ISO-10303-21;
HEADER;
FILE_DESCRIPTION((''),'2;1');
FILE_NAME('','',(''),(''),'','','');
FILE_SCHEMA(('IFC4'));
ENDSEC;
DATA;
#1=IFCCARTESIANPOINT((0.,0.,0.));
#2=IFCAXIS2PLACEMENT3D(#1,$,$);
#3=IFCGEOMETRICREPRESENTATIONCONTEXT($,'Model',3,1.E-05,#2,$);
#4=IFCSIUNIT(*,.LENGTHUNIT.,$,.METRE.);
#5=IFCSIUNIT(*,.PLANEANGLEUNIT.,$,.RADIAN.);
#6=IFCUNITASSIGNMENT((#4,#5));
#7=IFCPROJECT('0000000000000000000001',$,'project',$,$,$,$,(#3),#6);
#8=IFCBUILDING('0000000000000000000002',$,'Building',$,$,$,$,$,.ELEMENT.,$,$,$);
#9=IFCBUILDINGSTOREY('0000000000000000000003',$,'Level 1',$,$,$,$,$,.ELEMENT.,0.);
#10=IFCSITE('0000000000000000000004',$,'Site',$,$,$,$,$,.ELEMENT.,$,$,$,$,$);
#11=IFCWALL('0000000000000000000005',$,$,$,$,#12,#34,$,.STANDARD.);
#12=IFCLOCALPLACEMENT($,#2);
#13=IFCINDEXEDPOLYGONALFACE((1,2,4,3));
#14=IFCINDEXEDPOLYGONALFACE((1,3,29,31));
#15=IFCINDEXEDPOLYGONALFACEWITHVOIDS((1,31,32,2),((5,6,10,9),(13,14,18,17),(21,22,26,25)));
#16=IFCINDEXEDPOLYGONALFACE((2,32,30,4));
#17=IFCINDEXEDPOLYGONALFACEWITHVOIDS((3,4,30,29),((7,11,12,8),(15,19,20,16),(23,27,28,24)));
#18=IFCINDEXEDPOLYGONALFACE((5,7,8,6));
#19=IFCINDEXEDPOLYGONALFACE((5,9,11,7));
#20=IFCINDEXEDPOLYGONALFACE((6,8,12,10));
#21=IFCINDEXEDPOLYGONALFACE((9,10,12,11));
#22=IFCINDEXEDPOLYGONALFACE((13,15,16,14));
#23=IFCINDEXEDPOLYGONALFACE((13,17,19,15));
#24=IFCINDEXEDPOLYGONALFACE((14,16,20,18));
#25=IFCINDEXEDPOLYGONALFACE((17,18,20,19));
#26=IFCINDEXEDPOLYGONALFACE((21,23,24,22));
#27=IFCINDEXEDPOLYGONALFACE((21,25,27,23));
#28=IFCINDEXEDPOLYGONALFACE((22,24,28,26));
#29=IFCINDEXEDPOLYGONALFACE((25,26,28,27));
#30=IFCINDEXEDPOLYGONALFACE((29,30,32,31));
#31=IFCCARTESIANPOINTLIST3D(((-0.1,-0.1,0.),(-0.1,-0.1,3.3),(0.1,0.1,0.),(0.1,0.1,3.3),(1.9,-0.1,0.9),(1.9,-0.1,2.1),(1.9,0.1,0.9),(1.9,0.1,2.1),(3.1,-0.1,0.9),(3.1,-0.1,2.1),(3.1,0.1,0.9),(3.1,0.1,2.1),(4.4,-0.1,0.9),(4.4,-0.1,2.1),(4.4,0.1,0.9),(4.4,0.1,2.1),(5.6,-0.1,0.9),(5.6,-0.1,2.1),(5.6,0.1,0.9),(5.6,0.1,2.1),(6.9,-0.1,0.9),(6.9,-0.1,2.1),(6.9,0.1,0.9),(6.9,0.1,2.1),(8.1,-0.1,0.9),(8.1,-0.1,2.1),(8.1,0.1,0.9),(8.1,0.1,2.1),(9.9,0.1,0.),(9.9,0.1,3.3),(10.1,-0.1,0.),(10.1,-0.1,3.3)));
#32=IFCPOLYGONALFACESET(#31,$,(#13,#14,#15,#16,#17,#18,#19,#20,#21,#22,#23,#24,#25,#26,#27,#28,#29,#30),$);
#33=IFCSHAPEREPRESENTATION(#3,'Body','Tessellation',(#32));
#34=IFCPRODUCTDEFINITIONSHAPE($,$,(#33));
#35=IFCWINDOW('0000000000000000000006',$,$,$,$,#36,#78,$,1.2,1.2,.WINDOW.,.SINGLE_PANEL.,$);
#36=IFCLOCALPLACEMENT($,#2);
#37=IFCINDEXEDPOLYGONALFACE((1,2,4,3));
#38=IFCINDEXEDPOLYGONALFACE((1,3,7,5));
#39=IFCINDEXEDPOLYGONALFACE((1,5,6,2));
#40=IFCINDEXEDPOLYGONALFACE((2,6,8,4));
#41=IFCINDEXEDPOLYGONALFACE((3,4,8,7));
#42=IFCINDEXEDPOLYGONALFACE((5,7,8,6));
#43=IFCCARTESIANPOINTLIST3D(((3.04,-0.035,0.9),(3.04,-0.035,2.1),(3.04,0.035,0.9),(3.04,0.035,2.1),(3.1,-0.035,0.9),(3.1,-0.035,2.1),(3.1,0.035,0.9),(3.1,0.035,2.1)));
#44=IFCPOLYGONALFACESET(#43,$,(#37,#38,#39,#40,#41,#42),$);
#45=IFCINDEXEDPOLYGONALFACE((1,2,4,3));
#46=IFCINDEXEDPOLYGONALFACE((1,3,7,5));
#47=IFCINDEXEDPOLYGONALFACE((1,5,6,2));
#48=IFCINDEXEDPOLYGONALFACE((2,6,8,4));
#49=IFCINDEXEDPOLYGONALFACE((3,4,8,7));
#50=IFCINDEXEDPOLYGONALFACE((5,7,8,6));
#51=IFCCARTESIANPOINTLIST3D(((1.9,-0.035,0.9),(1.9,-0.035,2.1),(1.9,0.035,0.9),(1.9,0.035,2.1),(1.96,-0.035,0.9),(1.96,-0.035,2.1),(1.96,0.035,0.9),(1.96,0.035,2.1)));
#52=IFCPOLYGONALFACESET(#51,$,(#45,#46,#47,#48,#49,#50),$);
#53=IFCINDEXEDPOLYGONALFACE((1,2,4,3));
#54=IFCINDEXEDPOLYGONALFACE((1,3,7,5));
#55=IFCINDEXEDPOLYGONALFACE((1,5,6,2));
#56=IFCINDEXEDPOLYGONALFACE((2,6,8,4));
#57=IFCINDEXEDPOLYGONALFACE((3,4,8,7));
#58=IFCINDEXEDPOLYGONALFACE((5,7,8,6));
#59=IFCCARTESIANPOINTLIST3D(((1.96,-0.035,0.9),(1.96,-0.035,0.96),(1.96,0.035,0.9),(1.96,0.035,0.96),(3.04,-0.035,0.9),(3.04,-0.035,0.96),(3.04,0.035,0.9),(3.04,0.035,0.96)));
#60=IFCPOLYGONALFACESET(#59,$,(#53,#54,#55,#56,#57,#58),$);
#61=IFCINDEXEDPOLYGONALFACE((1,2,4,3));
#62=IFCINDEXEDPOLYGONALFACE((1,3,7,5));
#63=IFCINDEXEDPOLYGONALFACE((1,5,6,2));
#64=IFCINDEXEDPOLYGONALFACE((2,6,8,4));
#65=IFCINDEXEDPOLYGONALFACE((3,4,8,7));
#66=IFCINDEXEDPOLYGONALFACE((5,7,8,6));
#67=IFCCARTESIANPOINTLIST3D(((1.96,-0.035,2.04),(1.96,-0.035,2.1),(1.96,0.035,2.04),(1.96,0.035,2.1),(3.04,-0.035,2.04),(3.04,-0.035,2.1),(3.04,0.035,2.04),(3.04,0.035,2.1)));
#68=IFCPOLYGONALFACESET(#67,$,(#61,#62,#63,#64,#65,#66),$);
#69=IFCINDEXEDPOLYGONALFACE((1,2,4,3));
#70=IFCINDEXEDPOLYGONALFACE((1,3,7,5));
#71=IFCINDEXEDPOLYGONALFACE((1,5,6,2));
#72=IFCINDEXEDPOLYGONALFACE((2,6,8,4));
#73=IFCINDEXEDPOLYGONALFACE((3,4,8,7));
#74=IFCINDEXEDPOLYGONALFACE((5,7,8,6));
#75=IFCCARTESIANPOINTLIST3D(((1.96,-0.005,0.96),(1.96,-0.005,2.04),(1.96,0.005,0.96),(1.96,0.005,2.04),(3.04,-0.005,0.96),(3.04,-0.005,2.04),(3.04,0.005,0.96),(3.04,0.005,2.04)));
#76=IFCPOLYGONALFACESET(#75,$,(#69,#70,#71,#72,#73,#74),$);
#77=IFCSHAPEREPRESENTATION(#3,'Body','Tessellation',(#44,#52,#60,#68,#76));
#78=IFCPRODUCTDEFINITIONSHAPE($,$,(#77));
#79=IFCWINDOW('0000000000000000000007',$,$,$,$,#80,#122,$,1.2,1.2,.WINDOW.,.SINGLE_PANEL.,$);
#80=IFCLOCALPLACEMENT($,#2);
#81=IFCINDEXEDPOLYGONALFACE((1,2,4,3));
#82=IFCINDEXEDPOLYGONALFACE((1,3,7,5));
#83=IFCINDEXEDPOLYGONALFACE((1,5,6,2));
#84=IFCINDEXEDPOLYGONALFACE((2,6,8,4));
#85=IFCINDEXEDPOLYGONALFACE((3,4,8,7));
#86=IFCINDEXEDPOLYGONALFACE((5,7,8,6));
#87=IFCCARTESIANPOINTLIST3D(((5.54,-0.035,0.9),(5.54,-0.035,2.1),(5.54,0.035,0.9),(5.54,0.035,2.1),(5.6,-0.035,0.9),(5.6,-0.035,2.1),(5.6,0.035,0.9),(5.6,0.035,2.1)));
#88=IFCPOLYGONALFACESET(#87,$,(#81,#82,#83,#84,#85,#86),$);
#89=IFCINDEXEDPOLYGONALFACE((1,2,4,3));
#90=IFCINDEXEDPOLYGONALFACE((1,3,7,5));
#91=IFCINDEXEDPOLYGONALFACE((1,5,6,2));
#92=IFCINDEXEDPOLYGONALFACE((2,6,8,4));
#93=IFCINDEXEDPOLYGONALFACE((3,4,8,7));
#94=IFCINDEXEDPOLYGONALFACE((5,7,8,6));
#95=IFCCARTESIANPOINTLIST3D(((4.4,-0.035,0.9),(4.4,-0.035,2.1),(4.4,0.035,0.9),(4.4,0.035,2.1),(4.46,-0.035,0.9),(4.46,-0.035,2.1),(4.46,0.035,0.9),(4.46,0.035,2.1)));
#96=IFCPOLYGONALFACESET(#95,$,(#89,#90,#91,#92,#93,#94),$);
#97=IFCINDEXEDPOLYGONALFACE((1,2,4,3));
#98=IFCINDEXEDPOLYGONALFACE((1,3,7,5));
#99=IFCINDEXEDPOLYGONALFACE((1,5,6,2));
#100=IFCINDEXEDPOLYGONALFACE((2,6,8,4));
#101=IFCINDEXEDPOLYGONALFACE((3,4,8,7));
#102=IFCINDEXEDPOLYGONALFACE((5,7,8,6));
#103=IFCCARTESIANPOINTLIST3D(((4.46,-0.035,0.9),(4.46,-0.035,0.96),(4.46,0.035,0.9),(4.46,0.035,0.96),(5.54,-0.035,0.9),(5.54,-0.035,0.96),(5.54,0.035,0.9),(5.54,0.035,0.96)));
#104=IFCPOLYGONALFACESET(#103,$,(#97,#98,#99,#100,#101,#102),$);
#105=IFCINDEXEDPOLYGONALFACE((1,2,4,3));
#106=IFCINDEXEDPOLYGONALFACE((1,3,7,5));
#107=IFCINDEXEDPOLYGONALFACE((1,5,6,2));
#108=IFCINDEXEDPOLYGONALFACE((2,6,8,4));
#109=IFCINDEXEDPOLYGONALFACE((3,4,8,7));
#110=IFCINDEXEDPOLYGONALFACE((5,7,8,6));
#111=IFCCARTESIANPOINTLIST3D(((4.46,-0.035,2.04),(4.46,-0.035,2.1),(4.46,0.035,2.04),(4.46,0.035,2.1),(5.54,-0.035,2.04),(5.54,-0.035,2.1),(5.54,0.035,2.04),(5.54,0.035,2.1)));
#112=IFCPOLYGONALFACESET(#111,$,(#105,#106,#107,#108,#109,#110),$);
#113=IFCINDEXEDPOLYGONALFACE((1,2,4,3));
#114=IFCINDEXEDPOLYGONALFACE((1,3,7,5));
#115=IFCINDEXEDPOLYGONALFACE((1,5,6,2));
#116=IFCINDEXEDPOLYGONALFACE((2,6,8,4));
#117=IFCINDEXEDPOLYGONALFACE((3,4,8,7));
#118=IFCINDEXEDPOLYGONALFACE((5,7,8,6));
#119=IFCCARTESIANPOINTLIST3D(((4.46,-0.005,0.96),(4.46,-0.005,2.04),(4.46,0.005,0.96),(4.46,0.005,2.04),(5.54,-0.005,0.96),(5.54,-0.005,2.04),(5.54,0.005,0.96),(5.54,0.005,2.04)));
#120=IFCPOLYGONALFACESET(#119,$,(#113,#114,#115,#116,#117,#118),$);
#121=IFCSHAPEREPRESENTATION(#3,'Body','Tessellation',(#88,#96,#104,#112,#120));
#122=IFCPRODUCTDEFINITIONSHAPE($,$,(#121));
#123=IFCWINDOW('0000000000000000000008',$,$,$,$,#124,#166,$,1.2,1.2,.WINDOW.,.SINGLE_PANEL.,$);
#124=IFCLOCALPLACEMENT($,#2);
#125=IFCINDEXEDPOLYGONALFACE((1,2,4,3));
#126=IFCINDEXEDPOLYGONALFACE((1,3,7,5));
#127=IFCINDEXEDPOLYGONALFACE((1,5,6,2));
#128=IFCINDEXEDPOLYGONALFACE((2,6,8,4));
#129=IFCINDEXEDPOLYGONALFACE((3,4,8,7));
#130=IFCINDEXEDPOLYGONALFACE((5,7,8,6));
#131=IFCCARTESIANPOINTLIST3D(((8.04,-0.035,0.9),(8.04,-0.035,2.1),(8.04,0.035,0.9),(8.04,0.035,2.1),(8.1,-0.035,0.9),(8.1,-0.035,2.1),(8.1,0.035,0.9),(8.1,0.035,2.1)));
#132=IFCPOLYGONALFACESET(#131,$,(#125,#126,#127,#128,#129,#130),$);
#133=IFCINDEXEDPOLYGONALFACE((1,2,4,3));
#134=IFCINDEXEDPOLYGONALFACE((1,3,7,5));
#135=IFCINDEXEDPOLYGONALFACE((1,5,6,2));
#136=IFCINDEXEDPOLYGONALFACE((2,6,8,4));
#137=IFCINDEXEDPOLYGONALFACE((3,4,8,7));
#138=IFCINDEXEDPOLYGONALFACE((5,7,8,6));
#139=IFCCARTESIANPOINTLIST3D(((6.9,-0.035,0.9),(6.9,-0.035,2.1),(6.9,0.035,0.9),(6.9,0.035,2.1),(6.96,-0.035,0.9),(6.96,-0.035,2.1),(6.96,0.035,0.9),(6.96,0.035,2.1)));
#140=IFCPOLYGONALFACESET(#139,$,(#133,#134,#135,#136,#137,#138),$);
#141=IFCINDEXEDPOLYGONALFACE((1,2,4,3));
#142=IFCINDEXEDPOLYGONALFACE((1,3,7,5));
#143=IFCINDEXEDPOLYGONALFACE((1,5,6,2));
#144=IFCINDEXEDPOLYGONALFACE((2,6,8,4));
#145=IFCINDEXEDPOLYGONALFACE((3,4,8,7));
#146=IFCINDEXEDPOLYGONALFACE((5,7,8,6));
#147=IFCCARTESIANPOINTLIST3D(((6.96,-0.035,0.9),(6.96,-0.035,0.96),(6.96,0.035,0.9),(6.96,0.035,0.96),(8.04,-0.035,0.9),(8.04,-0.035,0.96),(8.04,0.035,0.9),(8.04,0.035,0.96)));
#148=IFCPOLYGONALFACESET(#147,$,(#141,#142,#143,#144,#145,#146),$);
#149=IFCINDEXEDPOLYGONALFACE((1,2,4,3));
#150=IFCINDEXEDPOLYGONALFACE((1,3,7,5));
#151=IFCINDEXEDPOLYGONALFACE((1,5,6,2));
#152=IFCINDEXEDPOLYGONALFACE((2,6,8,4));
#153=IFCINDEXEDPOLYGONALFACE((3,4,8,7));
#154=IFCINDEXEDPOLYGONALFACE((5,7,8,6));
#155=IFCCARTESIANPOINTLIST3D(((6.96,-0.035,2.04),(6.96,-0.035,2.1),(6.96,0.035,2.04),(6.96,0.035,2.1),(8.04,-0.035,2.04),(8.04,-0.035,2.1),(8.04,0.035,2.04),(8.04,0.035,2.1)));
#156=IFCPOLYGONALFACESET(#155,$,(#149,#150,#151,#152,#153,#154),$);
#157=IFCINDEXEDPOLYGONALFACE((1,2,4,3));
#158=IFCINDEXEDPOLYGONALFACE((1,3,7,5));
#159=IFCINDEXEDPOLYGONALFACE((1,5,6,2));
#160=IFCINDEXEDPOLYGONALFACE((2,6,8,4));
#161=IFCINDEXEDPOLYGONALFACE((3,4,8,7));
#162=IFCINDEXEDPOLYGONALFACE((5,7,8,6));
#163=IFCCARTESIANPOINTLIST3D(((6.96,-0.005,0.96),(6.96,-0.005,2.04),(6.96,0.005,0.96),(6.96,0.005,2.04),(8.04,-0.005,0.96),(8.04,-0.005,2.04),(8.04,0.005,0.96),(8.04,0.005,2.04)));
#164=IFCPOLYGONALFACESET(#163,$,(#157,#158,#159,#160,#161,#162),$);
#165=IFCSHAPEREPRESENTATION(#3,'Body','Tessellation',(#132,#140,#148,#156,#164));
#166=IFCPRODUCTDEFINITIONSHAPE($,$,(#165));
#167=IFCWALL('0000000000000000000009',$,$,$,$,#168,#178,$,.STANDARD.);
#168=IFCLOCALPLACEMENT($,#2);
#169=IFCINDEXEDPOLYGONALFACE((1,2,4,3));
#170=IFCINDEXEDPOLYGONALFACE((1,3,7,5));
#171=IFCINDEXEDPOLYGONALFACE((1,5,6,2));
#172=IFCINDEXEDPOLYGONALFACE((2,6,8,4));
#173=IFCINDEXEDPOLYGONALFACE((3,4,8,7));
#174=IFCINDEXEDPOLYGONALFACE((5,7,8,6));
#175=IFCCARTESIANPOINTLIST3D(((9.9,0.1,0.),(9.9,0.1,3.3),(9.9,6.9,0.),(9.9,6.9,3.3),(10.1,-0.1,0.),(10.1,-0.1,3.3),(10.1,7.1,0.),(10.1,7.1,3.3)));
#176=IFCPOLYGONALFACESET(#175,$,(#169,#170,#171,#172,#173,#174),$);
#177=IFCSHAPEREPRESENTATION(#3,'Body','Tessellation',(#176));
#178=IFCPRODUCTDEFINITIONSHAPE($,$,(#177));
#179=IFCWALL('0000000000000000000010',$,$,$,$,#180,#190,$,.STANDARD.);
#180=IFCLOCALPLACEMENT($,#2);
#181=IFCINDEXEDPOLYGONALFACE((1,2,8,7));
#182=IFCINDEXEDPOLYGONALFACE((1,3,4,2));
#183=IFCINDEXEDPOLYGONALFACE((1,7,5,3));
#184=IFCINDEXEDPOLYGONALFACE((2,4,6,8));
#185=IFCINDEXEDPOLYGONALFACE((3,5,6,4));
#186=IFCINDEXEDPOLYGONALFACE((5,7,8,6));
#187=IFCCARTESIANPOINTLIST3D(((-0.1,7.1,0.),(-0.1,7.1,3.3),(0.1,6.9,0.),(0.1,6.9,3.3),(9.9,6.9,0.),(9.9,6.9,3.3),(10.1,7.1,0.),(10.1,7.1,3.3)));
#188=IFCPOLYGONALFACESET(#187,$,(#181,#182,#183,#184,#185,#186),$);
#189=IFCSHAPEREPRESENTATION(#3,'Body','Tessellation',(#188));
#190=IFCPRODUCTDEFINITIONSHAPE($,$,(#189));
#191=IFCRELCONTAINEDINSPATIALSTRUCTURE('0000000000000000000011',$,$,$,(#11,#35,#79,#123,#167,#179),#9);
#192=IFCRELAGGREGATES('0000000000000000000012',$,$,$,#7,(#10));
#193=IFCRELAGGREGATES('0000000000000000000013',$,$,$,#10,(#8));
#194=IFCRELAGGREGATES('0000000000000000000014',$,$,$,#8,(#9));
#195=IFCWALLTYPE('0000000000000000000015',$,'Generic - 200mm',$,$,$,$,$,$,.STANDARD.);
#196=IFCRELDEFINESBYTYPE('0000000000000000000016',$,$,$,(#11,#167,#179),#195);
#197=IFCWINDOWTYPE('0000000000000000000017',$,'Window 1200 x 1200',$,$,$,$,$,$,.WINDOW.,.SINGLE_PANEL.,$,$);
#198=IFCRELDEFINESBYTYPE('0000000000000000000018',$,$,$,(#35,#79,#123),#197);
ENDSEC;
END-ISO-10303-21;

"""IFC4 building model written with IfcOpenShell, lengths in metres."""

from ifc_helpers import new_model, si_unit, frame, frame_2d, origin, origin_with_axes, origin_2d, place, context, project, spatial, polyline, rectangle, outline, extrude, type_object, element, fill, save


model = new_model("IFC4")

# Units and contexts
model_context = context("Model", 3, precision=1e-05, world=origin())
ifc_project = project(units=[si_unit("LENGTHUNIT", "METRE"), si_unit("PLANEANGLEUNIT", "RADIAN")], contexts=[model_context])

# Site, building, storey
site = spatial("IfcSite", under=ifc_project, Name="Site", CompositionType="ELEMENT")
building = spatial("IfcBuilding", under=site, Name="Building", CompositionType="ELEMENT")
storey = spatial("IfcBuildingStorey", under=building, Name="Level 1", CompositionType="ELEMENT", Elevation=0.0)

# Wall, openings, windows
wall_type = type_object("IfcWallType", Name="Generic - 200mm", PredefinedType="STANDARD")
wall_1_placement = place(None, frame((10.0, 0.0, 0.0), z_axis=(0.0, 0.0, 1.0), x_axis=(-1.0, 0.0, 0.0)))
wall_1 = element("IfcWall", 1, at=wall_1_placement, inside=storey, type_object=wall_type, PredefinedType="STANDARD", context=model_context, shape_type="SweptSolid", body=[
    extrude(outline(polyline([(0.1, -0.1), (9.9, -0.1), (10.1, 0.1), (-0.1, 0.1), (0.1, -0.1)])), origin(), (0.0, 0.0, 1.0), 3.3),
])
opening_1_placement = place(wall_1_placement, frame((7.5, 0.0, 0.9), z_axis=(0.0, 0.0, 1.0), x_axis=(1.0, 0.0, 0.0)))
opening_1 = element("IfcOpeningElement", 2, at=opening_1_placement, cuts=wall_1, PredefinedType="OPENING", context=model_context, shape_type="SweptSolid", body=[
    extrude(rectangle(XDim=1.2, YDim=0.202, at=origin_2d()), origin(), (0.0, 0.0, 1.0), 1.2),
])
opening_2_placement = place(wall_1_placement, frame((5.0, 0.0, 0.9), z_axis=(0.0, 0.0, 1.0), x_axis=(1.0, 0.0, 0.0)))
opening_2 = element("IfcOpeningElement", 3, at=opening_2_placement, cuts=wall_1, PredefinedType="OPENING", context=model_context, shape_type="SweptSolid", body=[
    extrude(rectangle(XDim=1.2, YDim=0.202, at=origin_2d()), origin(), (0.0, 0.0, 1.0), 1.2),
])
opening_3_placement = place(wall_1_placement, frame((2.5, 0.0, 0.9), z_axis=(0.0, 0.0, 1.0), x_axis=(1.0, 0.0, 0.0)))
opening_3 = element("IfcOpeningElement", 4, at=opening_3_placement, cuts=wall_1, PredefinedType="OPENING", context=model_context, shape_type="SweptSolid", body=[
    extrude(rectangle(XDim=1.2, YDim=0.202, at=origin_2d()), origin(), (0.0, 0.0, 1.0), 1.2),
])
window_type = type_object("IfcWindowType", Name="Window 1200 x 1200", PartitioningType="SINGLE_PANEL", PredefinedType="WINDOW")
window_1_placement = place(opening_1_placement, origin_with_axes())
window_1 = element("IfcWindow", 5, at=window_1_placement, inside=storey, type_object=window_type, OverallHeight=1.2, OverallWidth=1.2, PartitioningType="SINGLE_PANEL", PredefinedType="WINDOW", context=model_context, shape_type="SweptSolid", body=[
    extrude(rectangle(XDim=0.06, YDim=0.07, at=frame_2d((-0.57, 0.0))), origin(), (0.0, 0.0, 1.0), 1.2),
    extrude(rectangle(XDim=0.06, YDim=0.07, at=frame_2d((0.57, 0.0))), origin(), (0.0, 0.0, 1.0), 1.2),
    extrude(rectangle(XDim=1.08, YDim=0.07, at=origin_2d()), origin(), (0.0, 0.0, 1.0), 0.06),
    extrude(rectangle(XDim=1.08, YDim=0.07, at=origin_2d()), frame((0.0, 0.0, 1.14)), (0.0, 0.0, 1.0), 0.06),
    extrude(rectangle(XDim=1.08, YDim=0.01, at=origin_2d()), frame((0.0, 0.0, 0.06)), (0.0, 0.0, 1.0), 1.08),
])
fill(opening_1, window_1)
window_2_placement = place(opening_2_placement, origin_with_axes())
window_2 = element("IfcWindow", 6, at=window_2_placement, inside=storey, type_object=window_type, OverallHeight=1.2, OverallWidth=1.2, PartitioningType="SINGLE_PANEL", PredefinedType="WINDOW", context=model_context, shape_type="SweptSolid", body=[
    extrude(rectangle(XDim=0.06, YDim=0.07, at=frame_2d((-0.57, 0.0))), origin(), (0.0, 0.0, 1.0), 1.2),
    extrude(rectangle(XDim=0.06, YDim=0.07, at=frame_2d((0.57, 0.0))), origin(), (0.0, 0.0, 1.0), 1.2),
    extrude(rectangle(XDim=1.08, YDim=0.07, at=origin_2d()), origin(), (0.0, 0.0, 1.0), 0.06),
    extrude(rectangle(XDim=1.08, YDim=0.07, at=origin_2d()), frame((0.0, 0.0, 1.14)), (0.0, 0.0, 1.0), 0.06),
    extrude(rectangle(XDim=1.08, YDim=0.01, at=origin_2d()), frame((0.0, 0.0, 0.06)), (0.0, 0.0, 1.0), 1.08),
])
fill(opening_2, window_2)
window_3_placement = place(opening_3_placement, origin_with_axes())
window_3 = element("IfcWindow", 7, at=window_3_placement, inside=storey, type_object=window_type, OverallHeight=1.2, OverallWidth=1.2, PartitioningType="SINGLE_PANEL", PredefinedType="WINDOW", context=model_context, shape_type="SweptSolid", body=[
    extrude(rectangle(XDim=0.06, YDim=0.07, at=frame_2d((-0.57, 0.0))), origin(), (0.0, 0.0, 1.0), 1.2),
    extrude(rectangle(XDim=0.06, YDim=0.07, at=frame_2d((0.57, 0.0))), origin(), (0.0, 0.0, 1.0), 1.2),
    extrude(rectangle(XDim=1.08, YDim=0.07, at=origin_2d()), origin(), (0.0, 0.0, 1.0), 0.06),
    extrude(rectangle(XDim=1.08, YDim=0.07, at=origin_2d()), frame((0.0, 0.0, 1.14)), (0.0, 0.0, 1.0), 0.06),
    extrude(rectangle(XDim=1.08, YDim=0.01, at=origin_2d()), frame((0.0, 0.0, 0.06)), (0.0, 0.0, 1.0), 1.08),
])
fill(opening_3, window_3)

# Walls
wall_2_placement = place(None, frame((10.0, 7.0, 0.0), z_axis=(0.0, 0.0, 1.0), x_axis=(0.0, -1.0, 0.0)))
element("IfcWall", 8, at=wall_2_placement, inside=storey, type_object=wall_type, PredefinedType="STANDARD", context=model_context, shape_type="SweptSolid", body=[
    extrude(outline(polyline([(0.1, -0.1), (6.9, -0.1), (7.1, 0.1), (-0.1, 0.1), (0.1, -0.1)])), origin(), (0.0, 0.0, 1.0), 3.3),
])
wall_3_placement = place(None, frame((0.0, 7.0, 0.0), z_axis=(0.0, 0.0, 1.0), x_axis=(1.0, 0.0, 0.0)))
element("IfcWall", 9, at=wall_3_placement, inside=storey, type_object=wall_type, PredefinedType="STANDARD", context=model_context, shape_type="SweptSolid", body=[
    extrude(outline(polyline([(0.1, -0.1), (9.9, -0.1), (10.1, 0.1), (-0.1, 0.1), (0.1, -0.1)])), origin(), (0.0, 0.0, 1.0), 3.3),
])

save(model, "model.ifc")
